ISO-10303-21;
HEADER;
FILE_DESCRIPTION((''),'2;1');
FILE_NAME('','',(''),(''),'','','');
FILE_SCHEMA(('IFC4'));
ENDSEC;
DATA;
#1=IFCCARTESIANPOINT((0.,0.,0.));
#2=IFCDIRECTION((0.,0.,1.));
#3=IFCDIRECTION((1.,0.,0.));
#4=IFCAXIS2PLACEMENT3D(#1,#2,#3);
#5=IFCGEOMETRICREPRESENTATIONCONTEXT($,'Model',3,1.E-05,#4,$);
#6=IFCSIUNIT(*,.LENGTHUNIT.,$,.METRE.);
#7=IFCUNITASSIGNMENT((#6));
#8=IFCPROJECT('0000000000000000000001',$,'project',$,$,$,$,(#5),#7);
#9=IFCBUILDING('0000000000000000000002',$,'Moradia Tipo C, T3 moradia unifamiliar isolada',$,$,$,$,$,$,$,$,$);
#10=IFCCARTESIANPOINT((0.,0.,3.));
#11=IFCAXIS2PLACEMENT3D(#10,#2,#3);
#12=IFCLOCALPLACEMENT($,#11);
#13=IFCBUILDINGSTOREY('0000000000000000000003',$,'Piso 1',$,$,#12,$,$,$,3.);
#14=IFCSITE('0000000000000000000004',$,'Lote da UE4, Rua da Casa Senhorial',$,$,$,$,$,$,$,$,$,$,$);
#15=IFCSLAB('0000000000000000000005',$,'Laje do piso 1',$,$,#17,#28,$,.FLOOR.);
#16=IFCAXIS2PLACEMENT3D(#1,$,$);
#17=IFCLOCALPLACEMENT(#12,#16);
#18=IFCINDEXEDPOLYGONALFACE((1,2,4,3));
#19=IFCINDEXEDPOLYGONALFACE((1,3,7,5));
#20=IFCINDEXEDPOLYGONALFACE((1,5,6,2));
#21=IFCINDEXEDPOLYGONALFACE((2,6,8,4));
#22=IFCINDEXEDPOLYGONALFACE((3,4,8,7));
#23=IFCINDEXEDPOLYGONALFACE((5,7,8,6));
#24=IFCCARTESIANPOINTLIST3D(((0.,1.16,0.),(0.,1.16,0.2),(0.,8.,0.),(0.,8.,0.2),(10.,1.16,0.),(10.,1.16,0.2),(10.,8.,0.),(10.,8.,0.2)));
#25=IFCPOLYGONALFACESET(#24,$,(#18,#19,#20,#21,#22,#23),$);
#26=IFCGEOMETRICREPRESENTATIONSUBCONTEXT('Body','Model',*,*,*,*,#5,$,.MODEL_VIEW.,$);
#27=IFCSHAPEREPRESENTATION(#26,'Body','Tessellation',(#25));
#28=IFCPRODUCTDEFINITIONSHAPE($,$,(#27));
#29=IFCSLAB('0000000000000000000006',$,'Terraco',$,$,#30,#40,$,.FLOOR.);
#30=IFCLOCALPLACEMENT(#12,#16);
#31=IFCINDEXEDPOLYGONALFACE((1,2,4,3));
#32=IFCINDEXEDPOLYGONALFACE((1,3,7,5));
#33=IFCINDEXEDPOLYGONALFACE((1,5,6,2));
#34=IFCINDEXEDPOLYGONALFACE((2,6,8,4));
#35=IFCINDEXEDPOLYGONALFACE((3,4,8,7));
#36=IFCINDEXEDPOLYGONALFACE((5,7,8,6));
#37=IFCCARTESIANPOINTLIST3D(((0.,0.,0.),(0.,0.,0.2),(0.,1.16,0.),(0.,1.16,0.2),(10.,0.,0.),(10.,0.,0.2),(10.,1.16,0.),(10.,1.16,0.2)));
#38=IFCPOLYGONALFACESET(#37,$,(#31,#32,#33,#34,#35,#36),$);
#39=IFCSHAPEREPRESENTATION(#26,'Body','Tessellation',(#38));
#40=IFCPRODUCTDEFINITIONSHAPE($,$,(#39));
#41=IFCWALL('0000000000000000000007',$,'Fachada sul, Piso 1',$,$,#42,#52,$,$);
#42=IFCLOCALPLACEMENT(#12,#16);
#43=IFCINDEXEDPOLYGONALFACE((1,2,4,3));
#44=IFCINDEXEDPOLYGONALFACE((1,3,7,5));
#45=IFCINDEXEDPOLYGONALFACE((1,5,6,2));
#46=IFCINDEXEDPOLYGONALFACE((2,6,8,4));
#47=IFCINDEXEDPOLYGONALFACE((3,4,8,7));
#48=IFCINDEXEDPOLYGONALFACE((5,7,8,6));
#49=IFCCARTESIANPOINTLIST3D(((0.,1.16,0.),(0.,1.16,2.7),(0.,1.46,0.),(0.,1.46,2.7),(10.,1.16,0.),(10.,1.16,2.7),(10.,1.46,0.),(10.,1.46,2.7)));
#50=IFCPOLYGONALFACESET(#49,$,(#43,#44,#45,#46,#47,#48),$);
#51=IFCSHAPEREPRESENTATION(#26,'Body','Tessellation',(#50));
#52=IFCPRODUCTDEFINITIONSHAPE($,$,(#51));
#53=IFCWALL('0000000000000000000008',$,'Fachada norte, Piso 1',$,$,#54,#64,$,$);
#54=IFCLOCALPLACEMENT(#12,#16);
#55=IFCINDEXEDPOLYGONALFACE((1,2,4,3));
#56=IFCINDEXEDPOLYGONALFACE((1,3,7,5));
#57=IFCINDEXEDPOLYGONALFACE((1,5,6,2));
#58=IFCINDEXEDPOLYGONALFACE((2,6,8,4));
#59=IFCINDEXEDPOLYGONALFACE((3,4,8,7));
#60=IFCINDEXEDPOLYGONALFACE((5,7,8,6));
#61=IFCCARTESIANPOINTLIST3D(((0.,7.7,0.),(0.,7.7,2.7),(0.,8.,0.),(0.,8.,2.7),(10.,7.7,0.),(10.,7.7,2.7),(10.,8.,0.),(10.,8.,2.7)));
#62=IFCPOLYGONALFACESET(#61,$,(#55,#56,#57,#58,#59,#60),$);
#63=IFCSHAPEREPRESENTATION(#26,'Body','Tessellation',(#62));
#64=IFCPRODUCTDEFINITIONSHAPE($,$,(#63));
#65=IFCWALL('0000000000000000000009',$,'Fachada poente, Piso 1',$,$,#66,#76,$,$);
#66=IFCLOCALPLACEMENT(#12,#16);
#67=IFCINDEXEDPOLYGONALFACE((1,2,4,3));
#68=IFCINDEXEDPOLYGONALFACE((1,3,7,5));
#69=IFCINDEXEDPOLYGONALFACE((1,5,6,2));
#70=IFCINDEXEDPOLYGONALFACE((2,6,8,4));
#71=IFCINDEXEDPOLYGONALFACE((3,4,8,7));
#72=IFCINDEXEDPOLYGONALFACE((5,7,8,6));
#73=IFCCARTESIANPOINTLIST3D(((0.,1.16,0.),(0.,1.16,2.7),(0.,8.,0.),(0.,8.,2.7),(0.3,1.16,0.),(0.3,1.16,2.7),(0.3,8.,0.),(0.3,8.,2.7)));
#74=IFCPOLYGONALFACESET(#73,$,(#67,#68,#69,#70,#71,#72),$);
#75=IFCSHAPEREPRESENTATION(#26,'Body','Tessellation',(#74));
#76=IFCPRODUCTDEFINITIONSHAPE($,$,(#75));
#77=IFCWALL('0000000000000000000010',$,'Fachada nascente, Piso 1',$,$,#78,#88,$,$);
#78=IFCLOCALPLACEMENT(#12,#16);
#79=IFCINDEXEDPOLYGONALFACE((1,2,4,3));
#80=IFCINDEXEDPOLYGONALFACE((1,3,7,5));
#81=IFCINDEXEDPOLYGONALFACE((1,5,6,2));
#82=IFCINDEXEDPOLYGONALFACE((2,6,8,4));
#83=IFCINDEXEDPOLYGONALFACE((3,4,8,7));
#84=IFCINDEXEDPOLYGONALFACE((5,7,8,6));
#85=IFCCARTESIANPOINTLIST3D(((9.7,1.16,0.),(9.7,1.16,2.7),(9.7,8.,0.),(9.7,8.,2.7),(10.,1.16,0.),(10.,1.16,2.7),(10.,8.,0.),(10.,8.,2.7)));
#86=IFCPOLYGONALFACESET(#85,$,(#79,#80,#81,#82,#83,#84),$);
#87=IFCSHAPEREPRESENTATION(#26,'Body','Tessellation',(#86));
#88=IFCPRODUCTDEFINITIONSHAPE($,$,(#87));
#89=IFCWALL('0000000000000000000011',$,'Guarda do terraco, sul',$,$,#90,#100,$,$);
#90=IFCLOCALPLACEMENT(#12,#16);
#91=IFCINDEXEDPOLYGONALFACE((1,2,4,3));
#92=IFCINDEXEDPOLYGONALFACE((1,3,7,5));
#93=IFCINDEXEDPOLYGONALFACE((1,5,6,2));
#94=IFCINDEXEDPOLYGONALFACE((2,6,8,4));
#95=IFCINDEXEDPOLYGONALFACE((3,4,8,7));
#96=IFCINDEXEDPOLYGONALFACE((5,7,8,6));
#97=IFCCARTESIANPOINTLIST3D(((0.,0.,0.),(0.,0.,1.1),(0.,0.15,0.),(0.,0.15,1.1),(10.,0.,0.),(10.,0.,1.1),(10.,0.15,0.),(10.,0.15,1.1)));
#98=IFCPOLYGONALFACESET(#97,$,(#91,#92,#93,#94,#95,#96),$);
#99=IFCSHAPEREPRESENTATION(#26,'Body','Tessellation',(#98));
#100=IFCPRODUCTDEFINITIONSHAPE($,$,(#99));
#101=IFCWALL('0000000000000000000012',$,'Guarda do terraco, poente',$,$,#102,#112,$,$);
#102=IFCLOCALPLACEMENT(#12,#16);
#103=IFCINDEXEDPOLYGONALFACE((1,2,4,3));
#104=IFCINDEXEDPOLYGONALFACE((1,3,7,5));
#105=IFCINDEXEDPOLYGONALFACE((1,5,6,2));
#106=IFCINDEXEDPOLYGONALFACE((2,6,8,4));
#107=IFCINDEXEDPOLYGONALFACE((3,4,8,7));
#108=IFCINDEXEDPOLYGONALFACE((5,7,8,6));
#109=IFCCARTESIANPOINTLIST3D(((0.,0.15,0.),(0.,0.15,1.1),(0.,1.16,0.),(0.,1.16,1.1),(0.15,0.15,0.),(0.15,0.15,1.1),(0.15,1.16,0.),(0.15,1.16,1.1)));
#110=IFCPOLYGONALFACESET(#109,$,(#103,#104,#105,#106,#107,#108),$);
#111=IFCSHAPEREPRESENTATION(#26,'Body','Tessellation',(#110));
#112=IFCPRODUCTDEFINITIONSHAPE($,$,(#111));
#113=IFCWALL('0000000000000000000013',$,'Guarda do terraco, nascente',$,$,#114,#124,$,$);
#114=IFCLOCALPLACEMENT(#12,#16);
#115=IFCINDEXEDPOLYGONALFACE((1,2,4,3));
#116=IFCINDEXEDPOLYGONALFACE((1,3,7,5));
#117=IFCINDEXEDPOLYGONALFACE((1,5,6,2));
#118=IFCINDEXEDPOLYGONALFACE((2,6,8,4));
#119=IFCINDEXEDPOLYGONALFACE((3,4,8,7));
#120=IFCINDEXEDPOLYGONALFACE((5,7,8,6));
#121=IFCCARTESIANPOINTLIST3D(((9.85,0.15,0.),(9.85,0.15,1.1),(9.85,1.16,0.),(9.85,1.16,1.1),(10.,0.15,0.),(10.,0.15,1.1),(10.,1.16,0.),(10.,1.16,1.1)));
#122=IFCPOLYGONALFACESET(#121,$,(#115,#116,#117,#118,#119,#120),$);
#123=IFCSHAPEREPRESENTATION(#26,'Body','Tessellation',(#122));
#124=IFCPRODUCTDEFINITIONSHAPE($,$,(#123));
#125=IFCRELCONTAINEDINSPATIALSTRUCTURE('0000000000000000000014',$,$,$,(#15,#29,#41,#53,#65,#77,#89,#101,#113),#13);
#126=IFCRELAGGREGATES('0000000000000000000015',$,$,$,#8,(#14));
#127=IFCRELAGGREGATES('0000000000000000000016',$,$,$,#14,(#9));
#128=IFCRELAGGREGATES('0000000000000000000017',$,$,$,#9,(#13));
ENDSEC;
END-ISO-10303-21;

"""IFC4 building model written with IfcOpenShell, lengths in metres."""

from ifc_helpers import new_model, si_unit, frame, origin_with_axes, place, context, subcontext, project, spatial, indexed_curve, outline, extrude, element, save


model = new_model("IFC4")

# Units and contexts
model_context = context("Model", 3, precision=1e-05, world=origin_with_axes())
body_context = subcontext(model_context, "Body", "Model", "MODEL_VIEW")
ifc_project = project(units=[si_unit("LENGTHUNIT", "METRE")], contexts=[model_context])

# Site, building, storey
site = spatial("IfcSite", under=ifc_project, Name="Lote da UE4, Rua da Casa Senhorial")
building = spatial("IfcBuilding", under=site, Name="Moradia Tipo C, T3 moradia unifamiliar isolada")
storey_placement = place(None, frame((0.0, 0.0, 3.0), z_axis=(0.0, 0.0, 1.0), x_axis=(1.0, 0.0, 0.0)))
storey = spatial("IfcBuildingStorey", under=building, at=storey_placement, Name="Piso 1", Elevation=3.0)

# Slabs
slab_1_placement = place(storey_placement, frame((0.0, 1.16, 0.0), z_axis=(0.0, 0.0, 1.0), x_axis=(1.0, 0.0, 0.0)))
element("IfcSlab", 1, at=slab_1_placement, inside=storey, Name="Laje do piso 1", PredefinedType="FLOOR", context=body_context, shape_type="SweptSolid", body=[
    extrude(outline(indexed_curve([(0.0, 0.0), (10.0, 0.0), (10.0, 6.84), (0.0, 6.84), (0.0, 0.0)])), None, (0.0, 0.0, 1.0), 0.2),
])
slab_2_placement = place(storey_placement, origin_with_axes())
element("IfcSlab", 2, at=slab_2_placement, inside=storey, Name="Terraco", PredefinedType="FLOOR", context=body_context, shape_type="SweptSolid", body=[
    extrude(outline(indexed_curve([(0.0, 0.0), (10.0, 0.0), (10.0, 1.16), (0.0, 1.16), (0.0, 0.0)])), None, (0.0, 0.0, 1.0), 0.2),
])

# Walls
for number, where, z_axis, x_axis, name in (
    (3, (0.0, 1.16, 0.0), (0.0, 0.0, 1.0), (1.0, 0.0, 0.0), "Fachada sul, Piso 1"),
    (4, (0.0, 7.7, 0.0), (0.0, 0.0, 1.0), (1.0, 0.0, 0.0), "Fachada norte, Piso 1"),
):
    element("IfcWall", number, at=place(storey_placement, frame(where, z_axis=z_axis, x_axis=x_axis)), inside=storey, Name=name, context=body_context, shape_type="SweptSolid", body=[
        extrude(outline(indexed_curve([(0.0, 0.0), (0.0, 0.3), (10.0, 0.3), (10.0, 0.0), (0.0, 0.0)], self_intersect=False)), origin_with_axes(), (0.0, 0.0, 1.0), 2.7),
    ])
for number, where, z_axis, x_axis, name in (
    (5, (0.3, 1.16, 0.0), (0.0, 0.0, 1.0), (0.0, 1.0, 0.0), "Fachada poente, Piso 1"),
    (6, (10.0, 1.16, 0.0), (0.0, 0.0, 1.0), (0.0, 1.0, 0.0), "Fachada nascente, Piso 1"),
):
    element("IfcWall", number, at=place(storey_placement, frame(where, z_axis=z_axis, x_axis=x_axis)), inside=storey, Name=name, context=body_context, shape_type="SweptSolid", body=[
        extrude(outline(indexed_curve([(0.0, 0.0), (0.0, 0.3), (6.84, 0.3), (6.84, 0.0), (0.0, 0.0)], self_intersect=False)), origin_with_axes(), (0.0, 0.0, 1.0), 2.7),
    ])
wall_placement = place(storey_placement, origin_with_axes())
element("IfcWall", 7, at=wall_placement, inside=storey, Name="Guarda do terraco, sul", context=body_context, shape_type="SweptSolid", body=[
    extrude(outline(indexed_curve([(0.0, 0.0), (0.0, 0.15), (10.0, 0.15), (10.0, 0.0), (0.0, 0.0)], self_intersect=False)), origin_with_axes(), (0.0, 0.0, 1.0), 1.1),
])
for number, where, z_axis, x_axis, name in (
    (8, (0.15, 0.15, 0.0), (0.0, 0.0, 1.0), (0.0, 1.0, 0.0), "Guarda do terraco, poente"),
    (9, (10.0, 0.15, 0.0), (0.0, 0.0, 1.0), (0.0, 1.0, 0.0), "Guarda do terraco, nascente"),
):
    element("IfcWall", number, at=place(storey_placement, frame(where, z_axis=z_axis, x_axis=x_axis)), inside=storey, Name=name, context=body_context, shape_type="SweptSolid", body=[
        extrude(outline(indexed_curve([(0.0, 0.0), (0.0, 0.15), (1.01, 0.15), (1.01, 0.0), (0.0, 0.0)], self_intersect=False)), origin_with_axes(), (0.0, 0.0, 1.0), 1.1),
    ])

save(model, "model.ifc")
